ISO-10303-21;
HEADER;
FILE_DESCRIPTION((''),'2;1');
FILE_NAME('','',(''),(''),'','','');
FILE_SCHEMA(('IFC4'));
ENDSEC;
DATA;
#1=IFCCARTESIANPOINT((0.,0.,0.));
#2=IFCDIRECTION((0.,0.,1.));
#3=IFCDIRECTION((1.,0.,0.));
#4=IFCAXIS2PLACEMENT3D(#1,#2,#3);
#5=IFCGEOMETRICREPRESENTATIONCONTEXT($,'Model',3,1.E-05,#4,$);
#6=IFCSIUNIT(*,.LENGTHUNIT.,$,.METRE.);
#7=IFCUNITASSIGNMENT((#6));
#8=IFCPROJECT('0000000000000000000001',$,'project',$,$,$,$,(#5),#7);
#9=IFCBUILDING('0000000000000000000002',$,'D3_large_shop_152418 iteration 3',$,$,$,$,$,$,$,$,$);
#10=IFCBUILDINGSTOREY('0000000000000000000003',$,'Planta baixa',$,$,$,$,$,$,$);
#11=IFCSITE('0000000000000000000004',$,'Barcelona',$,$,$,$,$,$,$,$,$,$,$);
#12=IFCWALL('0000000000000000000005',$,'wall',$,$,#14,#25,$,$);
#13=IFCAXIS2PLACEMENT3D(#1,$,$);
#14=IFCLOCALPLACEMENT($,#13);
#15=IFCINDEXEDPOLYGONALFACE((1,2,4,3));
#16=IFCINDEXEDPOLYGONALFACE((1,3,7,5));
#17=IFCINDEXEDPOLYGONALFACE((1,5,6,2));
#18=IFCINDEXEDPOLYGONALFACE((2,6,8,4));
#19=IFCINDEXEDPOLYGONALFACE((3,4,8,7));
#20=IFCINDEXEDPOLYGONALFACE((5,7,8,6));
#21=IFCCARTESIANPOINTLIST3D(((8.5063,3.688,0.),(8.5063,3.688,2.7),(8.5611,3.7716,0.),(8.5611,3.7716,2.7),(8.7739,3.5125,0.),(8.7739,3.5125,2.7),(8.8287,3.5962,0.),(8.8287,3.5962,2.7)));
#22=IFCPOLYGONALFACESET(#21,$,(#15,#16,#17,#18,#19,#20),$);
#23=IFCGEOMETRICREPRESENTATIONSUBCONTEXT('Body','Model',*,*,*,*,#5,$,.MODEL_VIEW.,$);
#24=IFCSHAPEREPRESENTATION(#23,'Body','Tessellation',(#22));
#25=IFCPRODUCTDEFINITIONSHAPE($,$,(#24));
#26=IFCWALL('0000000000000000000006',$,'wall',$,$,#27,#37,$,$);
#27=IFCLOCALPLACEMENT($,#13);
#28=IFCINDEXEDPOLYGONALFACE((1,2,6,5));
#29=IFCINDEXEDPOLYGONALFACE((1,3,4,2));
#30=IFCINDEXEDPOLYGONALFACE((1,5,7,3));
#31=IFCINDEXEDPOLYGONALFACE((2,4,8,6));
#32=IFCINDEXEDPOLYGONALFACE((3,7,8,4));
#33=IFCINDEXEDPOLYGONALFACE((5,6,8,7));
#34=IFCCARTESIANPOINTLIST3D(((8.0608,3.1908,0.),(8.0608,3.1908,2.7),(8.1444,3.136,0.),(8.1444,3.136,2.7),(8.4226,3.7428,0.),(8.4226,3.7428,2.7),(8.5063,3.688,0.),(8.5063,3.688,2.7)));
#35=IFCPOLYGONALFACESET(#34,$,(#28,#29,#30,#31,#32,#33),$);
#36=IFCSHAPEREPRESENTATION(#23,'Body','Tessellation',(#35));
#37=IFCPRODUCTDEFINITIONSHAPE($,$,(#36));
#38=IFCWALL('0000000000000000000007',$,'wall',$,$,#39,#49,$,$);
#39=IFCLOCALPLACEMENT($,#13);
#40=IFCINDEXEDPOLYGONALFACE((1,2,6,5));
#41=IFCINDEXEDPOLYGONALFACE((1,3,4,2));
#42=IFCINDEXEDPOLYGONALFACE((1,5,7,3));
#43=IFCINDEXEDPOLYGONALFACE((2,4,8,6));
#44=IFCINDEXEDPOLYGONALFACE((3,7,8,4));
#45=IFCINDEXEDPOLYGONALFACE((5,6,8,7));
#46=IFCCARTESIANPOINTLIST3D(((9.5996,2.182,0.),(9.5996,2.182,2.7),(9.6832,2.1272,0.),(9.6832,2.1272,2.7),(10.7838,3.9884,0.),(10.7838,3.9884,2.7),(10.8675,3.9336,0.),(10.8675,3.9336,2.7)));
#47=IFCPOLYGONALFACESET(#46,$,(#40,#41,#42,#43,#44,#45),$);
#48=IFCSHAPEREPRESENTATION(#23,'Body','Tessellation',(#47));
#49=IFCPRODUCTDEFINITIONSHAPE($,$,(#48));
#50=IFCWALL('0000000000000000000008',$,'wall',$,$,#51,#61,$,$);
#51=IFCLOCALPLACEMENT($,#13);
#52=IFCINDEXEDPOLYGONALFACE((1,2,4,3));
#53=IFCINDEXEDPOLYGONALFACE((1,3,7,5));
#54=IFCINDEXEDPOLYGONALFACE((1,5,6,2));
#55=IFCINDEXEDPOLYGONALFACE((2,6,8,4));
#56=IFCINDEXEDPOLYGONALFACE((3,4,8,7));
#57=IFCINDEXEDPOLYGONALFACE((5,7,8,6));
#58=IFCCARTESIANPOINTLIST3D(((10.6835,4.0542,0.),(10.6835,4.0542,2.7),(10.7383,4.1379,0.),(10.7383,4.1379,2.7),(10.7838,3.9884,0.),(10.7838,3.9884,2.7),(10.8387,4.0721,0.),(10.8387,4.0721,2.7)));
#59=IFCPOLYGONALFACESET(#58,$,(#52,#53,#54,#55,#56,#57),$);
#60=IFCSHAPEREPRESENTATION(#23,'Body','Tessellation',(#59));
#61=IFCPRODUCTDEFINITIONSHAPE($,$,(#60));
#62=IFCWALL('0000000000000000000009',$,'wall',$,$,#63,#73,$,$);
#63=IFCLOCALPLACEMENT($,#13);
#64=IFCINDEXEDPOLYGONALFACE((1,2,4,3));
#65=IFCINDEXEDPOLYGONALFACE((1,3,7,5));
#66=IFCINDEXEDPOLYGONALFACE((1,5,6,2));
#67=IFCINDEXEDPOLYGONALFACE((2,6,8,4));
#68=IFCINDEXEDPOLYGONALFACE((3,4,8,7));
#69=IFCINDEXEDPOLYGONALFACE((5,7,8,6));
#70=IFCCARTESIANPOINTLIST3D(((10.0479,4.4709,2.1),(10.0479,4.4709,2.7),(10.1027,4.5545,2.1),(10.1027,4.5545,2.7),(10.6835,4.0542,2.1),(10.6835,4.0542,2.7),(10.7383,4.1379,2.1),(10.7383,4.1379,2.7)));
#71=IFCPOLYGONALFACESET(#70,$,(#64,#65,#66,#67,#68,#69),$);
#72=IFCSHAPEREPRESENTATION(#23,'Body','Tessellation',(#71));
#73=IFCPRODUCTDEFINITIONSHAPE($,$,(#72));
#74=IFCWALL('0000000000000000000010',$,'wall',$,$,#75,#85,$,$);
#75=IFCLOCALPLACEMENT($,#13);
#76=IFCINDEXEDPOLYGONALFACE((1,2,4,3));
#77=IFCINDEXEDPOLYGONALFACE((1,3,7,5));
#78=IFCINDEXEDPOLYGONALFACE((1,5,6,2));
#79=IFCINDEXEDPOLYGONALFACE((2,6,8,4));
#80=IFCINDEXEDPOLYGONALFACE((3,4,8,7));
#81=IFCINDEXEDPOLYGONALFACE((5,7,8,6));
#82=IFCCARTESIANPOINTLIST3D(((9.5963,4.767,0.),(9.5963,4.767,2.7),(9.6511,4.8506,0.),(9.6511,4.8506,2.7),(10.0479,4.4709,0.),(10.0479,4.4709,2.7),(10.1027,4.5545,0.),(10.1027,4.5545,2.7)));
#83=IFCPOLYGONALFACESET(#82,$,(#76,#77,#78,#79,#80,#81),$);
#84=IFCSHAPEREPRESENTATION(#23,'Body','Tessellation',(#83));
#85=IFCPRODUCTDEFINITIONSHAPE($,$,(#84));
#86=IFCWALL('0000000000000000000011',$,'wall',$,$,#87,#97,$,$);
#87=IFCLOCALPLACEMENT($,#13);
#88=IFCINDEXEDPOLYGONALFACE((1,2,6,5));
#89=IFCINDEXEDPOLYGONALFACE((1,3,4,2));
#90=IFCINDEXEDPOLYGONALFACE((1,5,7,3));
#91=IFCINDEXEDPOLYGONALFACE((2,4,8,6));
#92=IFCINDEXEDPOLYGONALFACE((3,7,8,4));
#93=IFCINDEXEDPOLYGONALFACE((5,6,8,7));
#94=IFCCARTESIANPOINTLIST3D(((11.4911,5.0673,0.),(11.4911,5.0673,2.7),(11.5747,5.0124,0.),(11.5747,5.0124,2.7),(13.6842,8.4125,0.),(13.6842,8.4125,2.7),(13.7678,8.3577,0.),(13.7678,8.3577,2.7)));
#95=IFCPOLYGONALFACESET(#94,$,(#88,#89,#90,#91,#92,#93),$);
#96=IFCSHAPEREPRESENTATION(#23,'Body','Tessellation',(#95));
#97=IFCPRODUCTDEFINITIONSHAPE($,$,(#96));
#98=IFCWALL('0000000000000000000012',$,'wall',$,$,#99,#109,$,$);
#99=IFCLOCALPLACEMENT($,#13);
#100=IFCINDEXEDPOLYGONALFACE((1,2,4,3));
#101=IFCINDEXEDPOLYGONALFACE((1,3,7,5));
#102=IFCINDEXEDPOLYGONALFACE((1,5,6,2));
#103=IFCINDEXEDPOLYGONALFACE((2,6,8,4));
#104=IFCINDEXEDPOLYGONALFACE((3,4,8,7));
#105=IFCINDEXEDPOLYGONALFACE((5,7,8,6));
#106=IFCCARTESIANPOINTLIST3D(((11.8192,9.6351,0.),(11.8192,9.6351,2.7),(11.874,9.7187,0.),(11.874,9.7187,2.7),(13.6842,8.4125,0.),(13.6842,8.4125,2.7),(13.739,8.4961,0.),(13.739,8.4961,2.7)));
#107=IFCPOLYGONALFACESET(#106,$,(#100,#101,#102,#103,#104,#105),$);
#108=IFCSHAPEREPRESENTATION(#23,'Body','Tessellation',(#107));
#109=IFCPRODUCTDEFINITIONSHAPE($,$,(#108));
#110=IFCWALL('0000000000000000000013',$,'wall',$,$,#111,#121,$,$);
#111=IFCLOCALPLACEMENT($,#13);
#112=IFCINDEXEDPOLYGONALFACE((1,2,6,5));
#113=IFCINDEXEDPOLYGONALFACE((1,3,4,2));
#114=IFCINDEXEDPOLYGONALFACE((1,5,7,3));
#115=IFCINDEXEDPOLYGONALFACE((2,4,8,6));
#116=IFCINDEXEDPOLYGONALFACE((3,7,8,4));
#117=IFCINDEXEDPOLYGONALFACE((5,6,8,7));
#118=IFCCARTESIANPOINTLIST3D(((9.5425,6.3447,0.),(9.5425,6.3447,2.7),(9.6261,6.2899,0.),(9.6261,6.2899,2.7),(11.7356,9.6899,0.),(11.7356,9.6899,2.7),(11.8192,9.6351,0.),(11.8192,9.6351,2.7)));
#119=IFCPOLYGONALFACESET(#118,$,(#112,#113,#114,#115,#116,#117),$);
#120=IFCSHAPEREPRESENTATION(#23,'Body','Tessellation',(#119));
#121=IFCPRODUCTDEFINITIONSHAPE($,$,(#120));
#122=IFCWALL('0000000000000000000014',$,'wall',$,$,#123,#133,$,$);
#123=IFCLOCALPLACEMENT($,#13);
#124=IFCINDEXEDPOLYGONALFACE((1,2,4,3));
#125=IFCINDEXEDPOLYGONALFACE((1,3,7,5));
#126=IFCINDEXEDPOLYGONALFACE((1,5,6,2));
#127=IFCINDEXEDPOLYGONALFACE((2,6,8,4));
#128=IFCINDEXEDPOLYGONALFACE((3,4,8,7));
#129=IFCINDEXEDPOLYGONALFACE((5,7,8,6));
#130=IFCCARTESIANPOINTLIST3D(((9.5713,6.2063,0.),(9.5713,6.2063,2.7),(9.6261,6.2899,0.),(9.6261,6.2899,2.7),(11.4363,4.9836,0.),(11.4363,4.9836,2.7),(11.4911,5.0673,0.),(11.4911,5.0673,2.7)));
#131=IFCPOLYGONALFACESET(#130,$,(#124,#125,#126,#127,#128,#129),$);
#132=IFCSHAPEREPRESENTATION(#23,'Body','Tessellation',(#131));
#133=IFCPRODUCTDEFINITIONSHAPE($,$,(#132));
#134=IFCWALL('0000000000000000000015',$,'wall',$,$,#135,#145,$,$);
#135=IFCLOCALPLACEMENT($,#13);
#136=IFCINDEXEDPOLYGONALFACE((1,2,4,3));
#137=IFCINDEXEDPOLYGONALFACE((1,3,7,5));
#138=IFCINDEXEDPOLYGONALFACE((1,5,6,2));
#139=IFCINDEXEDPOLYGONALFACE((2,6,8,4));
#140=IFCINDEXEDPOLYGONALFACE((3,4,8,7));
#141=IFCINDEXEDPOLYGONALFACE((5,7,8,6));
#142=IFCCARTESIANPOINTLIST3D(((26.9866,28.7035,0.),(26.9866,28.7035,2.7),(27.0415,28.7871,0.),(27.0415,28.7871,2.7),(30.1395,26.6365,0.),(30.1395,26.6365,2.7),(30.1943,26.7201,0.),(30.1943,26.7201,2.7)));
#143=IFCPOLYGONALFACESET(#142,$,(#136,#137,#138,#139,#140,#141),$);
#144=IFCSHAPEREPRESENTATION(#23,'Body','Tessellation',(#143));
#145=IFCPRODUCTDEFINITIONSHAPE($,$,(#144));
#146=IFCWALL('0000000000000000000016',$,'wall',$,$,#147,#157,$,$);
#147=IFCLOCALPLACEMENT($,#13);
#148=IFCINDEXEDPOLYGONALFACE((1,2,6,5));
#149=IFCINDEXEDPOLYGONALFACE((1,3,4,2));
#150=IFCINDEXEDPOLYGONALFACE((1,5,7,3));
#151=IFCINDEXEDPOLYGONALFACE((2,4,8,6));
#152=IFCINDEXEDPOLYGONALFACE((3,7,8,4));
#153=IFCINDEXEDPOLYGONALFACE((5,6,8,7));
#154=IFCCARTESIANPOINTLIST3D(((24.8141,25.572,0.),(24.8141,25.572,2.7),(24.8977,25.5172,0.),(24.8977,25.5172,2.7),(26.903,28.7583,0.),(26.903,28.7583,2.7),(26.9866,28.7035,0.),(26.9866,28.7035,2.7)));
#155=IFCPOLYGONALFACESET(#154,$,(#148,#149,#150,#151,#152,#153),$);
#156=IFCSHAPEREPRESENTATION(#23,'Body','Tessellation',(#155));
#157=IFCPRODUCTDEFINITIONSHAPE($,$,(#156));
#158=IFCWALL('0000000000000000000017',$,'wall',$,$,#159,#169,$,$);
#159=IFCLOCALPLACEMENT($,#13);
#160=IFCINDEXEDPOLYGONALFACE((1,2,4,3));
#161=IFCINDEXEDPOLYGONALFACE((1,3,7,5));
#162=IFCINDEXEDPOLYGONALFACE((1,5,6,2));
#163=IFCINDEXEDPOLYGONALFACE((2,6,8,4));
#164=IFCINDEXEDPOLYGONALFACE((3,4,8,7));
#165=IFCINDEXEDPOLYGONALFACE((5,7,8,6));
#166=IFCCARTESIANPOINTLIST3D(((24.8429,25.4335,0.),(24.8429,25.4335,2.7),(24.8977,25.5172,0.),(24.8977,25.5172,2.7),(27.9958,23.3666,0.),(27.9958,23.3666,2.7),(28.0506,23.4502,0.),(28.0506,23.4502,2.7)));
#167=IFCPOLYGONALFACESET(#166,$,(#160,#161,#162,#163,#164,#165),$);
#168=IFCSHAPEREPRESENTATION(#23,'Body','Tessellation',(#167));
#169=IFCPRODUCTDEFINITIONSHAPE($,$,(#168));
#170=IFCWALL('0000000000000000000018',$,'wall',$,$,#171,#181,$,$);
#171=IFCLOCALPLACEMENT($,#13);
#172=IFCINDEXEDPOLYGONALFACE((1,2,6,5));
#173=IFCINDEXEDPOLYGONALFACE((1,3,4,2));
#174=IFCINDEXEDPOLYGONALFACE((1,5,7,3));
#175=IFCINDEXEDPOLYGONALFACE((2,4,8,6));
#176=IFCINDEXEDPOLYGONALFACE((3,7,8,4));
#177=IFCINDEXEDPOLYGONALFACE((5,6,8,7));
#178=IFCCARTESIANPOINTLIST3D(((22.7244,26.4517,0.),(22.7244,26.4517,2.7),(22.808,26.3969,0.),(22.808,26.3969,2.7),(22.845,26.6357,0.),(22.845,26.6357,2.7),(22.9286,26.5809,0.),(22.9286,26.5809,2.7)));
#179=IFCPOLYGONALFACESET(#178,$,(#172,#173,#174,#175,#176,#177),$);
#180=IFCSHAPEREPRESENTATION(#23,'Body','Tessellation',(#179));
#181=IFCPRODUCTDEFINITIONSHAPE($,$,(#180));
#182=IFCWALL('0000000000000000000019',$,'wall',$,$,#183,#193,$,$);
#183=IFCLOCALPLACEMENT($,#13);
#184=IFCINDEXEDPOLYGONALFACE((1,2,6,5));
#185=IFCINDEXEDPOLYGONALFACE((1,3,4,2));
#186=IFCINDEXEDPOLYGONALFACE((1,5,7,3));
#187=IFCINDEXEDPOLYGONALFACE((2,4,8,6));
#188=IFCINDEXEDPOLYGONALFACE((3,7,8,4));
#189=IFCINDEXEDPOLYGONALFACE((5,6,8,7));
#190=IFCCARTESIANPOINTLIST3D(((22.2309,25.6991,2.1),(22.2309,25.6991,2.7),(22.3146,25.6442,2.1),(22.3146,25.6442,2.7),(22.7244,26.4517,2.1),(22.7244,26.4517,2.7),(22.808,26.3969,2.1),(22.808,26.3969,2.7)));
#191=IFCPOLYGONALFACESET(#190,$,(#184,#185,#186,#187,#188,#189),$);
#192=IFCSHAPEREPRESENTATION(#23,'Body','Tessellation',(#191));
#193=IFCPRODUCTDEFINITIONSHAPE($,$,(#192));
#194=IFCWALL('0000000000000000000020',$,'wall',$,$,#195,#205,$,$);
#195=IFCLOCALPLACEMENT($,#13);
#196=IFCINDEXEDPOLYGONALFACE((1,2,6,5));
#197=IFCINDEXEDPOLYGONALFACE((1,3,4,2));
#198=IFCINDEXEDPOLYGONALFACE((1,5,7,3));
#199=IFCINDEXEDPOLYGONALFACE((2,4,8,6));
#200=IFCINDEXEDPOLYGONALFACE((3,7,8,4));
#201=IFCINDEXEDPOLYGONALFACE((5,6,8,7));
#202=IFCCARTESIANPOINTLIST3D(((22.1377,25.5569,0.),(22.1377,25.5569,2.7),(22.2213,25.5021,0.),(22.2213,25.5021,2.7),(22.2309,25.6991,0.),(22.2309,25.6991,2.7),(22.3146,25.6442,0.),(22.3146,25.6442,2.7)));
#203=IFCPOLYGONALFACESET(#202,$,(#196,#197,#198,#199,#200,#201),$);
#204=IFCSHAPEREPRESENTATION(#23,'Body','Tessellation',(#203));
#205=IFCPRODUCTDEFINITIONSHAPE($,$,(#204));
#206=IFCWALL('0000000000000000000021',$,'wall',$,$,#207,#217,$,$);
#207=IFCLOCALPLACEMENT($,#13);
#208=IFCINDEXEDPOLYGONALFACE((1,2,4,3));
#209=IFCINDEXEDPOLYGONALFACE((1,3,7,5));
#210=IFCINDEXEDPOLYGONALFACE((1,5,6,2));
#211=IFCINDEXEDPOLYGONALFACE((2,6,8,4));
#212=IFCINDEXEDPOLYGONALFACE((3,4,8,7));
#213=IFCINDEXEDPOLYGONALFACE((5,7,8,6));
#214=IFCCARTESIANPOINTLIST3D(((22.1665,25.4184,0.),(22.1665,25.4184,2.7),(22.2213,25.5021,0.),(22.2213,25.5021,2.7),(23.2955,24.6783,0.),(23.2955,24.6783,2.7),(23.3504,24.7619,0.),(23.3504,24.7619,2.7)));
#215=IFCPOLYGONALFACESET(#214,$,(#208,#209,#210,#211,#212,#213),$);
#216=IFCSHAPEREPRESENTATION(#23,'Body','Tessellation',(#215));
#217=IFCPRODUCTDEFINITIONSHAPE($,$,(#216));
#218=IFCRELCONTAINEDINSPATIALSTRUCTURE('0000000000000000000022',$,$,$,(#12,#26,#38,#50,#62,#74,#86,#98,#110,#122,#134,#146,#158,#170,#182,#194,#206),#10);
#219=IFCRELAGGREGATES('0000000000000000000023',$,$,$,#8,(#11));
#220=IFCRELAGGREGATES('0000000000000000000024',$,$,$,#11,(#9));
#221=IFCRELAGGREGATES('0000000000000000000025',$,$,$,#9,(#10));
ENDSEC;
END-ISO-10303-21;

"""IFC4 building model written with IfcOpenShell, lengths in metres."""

from ifc_helpers import new_model, si_unit, frame, origin, origin_with_axes, place, context, subcontext, project, spatial, polyline, outline, extrude, element, save


model = new_model("IFC4")

# Units and contexts
model_context = context("Model", 3, precision=1e-05, world=origin_with_axes())
body_context = subcontext(model_context, "Body", "Model", "MODEL_VIEW")
ifc_project = project(units=[si_unit("LENGTHUNIT", "METRE")], contexts=[model_context])

# Site, building, storey
site = spatial("IfcSite", under=ifc_project, Name="Barcelona")
building = spatial("IfcBuilding", under=site, Name="D3_large_shop_152418 iteration 3")
storey = spatial("IfcBuildingStorey", under=building, Name="Planta baixa")

# Walls
wall_1_placement = place(None, origin_with_axes())
element("IfcWall", 1, at=wall_1_placement, inside=storey, Name="wall", context=body_context, shape_type="SweptSolid", body=[
    extrude(outline(polyline([(8.7739, 3.5125), (8.5063, 3.688), (8.5611, 3.7716), (8.8287, 3.5962), (8.7739, 3.5125)])), origin(), (0.0, 0.0, 1.0), 2.7),
])
wall_2_placement = place(None, origin_with_axes())
element("IfcWall", 2, at=wall_2_placement, inside=storey, Name="wall", context=body_context, shape_type="SweptSolid", body=[
    extrude(outline(polyline([(8.5063, 3.688), (8.1444, 3.136), (8.0608, 3.1908), (8.4226, 3.7428), (8.5063, 3.688)])), origin(), (0.0, 0.0, 1.0), 2.7),
])
wall_3_placement = place(None, origin_with_axes())
element("IfcWall", 3, at=wall_3_placement, inside=storey, Name="wall", context=body_context, shape_type="SweptSolid", body=[
    extrude(outline(polyline([(9.5996, 2.182), (10.7838, 3.9884), (10.8675, 3.9336), (9.6832, 2.1272), (9.5996, 2.182)])), origin(), (0.0, 0.0, 1.0), 2.7),
])
wall_4_placement = place(None, origin_with_axes())
element("IfcWall", 4, at=wall_4_placement, inside=storey, Name="wall", context=body_context, shape_type="SweptSolid", body=[
    extrude(outline(polyline([(10.7838, 3.9884), (10.6835, 4.0542), (10.7383, 4.1379), (10.8387, 4.0721), (10.7838, 3.9884)])), origin(), (0.0, 0.0, 1.0), 2.7),
])
wall_5_placement = place(None, origin_with_axes())
element("IfcWall", 5, at=wall_5_placement, inside=storey, Name="wall", context=body_context, shape_type="SweptSolid", body=[
    extrude(outline(polyline([(10.6835, 4.0542), (10.0479, 4.4709), (10.1027, 4.5545), (10.7383, 4.1379), (10.6835, 4.0542)])), frame((0.0, 0.0, 2.1)), (0.0, 0.0, 1.0), 0.6),
])
wall_6_placement = place(None, origin_with_axes())
element("IfcWall", 6, at=wall_6_placement, inside=storey, Name="wall", context=body_context, shape_type="SweptSolid", body=[
    extrude(outline(polyline([(10.0479, 4.4709), (9.5963, 4.767), (9.6511, 4.8506), (10.1027, 4.5545), (10.0479, 4.4709)])), origin(), (0.0, 0.0, 1.0), 2.7),
])
wall_7_placement = place(None, origin_with_axes())
element("IfcWall", 7, at=wall_7_placement, inside=storey, Name="wall", context=body_context, shape_type="SweptSolid", body=[
    extrude(outline(polyline([(11.4911, 5.0673), (13.6842, 8.4125), (13.7678, 8.3577), (11.5747, 5.0124), (11.4911, 5.0673)])), origin(), (0.0, 0.0, 1.0), 2.7),
])
wall_8_placement = place(None, origin_with_axes())
element("IfcWall", 8, at=wall_8_placement, inside=storey, Name="wall", context=body_context, shape_type="SweptSolid", body=[
    extrude(outline(polyline([(13.6842, 8.4125), (11.8192, 9.6351), (11.874, 9.7187), (13.739, 8.4961), (13.6842, 8.4125)])), origin(), (0.0, 0.0, 1.0), 2.7),
])
wall_9_placement = place(None, origin_with_axes())
element("IfcWall", 9, at=wall_9_placement, inside=storey, Name="wall", context=body_context, shape_type="SweptSolid", body=[
    extrude(outline(polyline([(11.8192, 9.6351), (9.6261, 6.2899), (9.5425, 6.3447), (11.7356, 9.6899), (11.8192, 9.6351)])), origin(), (0.0, 0.0, 1.0), 2.7),
])
wall_10_placement = place(None, origin_with_axes())
element("IfcWall", 10, at=wall_10_placement, inside=storey, Name="wall", context=body_context, shape_type="SweptSolid", body=[
    extrude(outline(polyline([(9.6261, 6.2899), (11.4911, 5.0673), (11.4363, 4.9836), (9.5713, 6.2063), (9.6261, 6.2899)])), origin(), (0.0, 0.0, 1.0), 2.7),
])
wall_11_placement = place(None, origin_with_axes())
element("IfcWall", 11, at=wall_11_placement, inside=storey, Name="wall", context=body_context, shape_type="SweptSolid", body=[
    extrude(outline(polyline([(30.1395, 26.6365), (26.9866, 28.7035), (27.0415, 28.7871), (30.1943, 26.7201), (30.1395, 26.6365)])), origin(), (0.0, 0.0, 1.0), 2.7),
])
wall_12_placement = place(None, origin_with_axes())
element("IfcWall", 12, at=wall_12_placement, inside=storey, Name="wall", context=body_context, shape_type="SweptSolid", body=[
    extrude(outline(polyline([(26.9866, 28.7035), (24.8977, 25.5172), (24.8141, 25.572), (26.903, 28.7583), (26.9866, 28.7035)])), origin(), (0.0, 0.0, 1.0), 2.7),
])
wall_13_placement = place(None, origin_with_axes())
element("IfcWall", 13, at=wall_13_placement, inside=storey, Name="wall", context=body_context, shape_type="SweptSolid", body=[
    extrude(outline(polyline([(24.8977, 25.5172), (28.0506, 23.4502), (27.9958, 23.3666), (24.8429, 25.4335), (24.8977, 25.5172)])), origin(), (0.0, 0.0, 1.0), 2.7),
])
wall_14_placement = place(None, origin_with_axes())
element("IfcWall", 14, at=wall_14_placement, inside=storey, Name="wall", context=body_context, shape_type="SweptSolid", body=[
    extrude(outline(polyline([(22.9286, 26.5809), (22.808, 26.3969), (22.7244, 26.4517), (22.845, 26.6357), (22.9286, 26.5809)])), origin(), (0.0, 0.0, 1.0), 2.7),
])
wall_15_placement = place(None, origin_with_axes())
element("IfcWall", 15, at=wall_15_placement, inside=storey, Name="wall", context=body_context, shape_type="SweptSolid", body=[
    extrude(outline(polyline([(22.808, 26.3969), (22.3146, 25.6442), (22.2309, 25.6991), (22.7244, 26.4517), (22.808, 26.3969)])), frame((0.0, 0.0, 2.1)), (0.0, 0.0, 1.0), 0.6),
])
wall_16_placement = place(None, origin_with_axes())
element("IfcWall", 16, at=wall_16_placement, inside=storey, Name="wall", context=body_context, shape_type="SweptSolid", body=[
    extrude(outline(polyline([(22.3146, 25.6442), (22.2213, 25.5021), (22.1377, 25.5569), (22.2309, 25.6991), (22.3146, 25.6442)])), origin(), (0.0, 0.0, 1.0), 2.7),
])
wall_17_placement = place(None, origin_with_axes())
element("IfcWall", 17, at=wall_17_placement, inside=storey, Name="wall", context=body_context, shape_type="SweptSolid", body=[
    extrude(outline(polyline([(22.2213, 25.5021), (23.3504, 24.7619), (23.2955, 24.6783), (22.1665, 25.4184), (22.2213, 25.5021)])), origin(), (0.0, 0.0, 1.0), 2.7),
])

save(model, "model.ifc")
